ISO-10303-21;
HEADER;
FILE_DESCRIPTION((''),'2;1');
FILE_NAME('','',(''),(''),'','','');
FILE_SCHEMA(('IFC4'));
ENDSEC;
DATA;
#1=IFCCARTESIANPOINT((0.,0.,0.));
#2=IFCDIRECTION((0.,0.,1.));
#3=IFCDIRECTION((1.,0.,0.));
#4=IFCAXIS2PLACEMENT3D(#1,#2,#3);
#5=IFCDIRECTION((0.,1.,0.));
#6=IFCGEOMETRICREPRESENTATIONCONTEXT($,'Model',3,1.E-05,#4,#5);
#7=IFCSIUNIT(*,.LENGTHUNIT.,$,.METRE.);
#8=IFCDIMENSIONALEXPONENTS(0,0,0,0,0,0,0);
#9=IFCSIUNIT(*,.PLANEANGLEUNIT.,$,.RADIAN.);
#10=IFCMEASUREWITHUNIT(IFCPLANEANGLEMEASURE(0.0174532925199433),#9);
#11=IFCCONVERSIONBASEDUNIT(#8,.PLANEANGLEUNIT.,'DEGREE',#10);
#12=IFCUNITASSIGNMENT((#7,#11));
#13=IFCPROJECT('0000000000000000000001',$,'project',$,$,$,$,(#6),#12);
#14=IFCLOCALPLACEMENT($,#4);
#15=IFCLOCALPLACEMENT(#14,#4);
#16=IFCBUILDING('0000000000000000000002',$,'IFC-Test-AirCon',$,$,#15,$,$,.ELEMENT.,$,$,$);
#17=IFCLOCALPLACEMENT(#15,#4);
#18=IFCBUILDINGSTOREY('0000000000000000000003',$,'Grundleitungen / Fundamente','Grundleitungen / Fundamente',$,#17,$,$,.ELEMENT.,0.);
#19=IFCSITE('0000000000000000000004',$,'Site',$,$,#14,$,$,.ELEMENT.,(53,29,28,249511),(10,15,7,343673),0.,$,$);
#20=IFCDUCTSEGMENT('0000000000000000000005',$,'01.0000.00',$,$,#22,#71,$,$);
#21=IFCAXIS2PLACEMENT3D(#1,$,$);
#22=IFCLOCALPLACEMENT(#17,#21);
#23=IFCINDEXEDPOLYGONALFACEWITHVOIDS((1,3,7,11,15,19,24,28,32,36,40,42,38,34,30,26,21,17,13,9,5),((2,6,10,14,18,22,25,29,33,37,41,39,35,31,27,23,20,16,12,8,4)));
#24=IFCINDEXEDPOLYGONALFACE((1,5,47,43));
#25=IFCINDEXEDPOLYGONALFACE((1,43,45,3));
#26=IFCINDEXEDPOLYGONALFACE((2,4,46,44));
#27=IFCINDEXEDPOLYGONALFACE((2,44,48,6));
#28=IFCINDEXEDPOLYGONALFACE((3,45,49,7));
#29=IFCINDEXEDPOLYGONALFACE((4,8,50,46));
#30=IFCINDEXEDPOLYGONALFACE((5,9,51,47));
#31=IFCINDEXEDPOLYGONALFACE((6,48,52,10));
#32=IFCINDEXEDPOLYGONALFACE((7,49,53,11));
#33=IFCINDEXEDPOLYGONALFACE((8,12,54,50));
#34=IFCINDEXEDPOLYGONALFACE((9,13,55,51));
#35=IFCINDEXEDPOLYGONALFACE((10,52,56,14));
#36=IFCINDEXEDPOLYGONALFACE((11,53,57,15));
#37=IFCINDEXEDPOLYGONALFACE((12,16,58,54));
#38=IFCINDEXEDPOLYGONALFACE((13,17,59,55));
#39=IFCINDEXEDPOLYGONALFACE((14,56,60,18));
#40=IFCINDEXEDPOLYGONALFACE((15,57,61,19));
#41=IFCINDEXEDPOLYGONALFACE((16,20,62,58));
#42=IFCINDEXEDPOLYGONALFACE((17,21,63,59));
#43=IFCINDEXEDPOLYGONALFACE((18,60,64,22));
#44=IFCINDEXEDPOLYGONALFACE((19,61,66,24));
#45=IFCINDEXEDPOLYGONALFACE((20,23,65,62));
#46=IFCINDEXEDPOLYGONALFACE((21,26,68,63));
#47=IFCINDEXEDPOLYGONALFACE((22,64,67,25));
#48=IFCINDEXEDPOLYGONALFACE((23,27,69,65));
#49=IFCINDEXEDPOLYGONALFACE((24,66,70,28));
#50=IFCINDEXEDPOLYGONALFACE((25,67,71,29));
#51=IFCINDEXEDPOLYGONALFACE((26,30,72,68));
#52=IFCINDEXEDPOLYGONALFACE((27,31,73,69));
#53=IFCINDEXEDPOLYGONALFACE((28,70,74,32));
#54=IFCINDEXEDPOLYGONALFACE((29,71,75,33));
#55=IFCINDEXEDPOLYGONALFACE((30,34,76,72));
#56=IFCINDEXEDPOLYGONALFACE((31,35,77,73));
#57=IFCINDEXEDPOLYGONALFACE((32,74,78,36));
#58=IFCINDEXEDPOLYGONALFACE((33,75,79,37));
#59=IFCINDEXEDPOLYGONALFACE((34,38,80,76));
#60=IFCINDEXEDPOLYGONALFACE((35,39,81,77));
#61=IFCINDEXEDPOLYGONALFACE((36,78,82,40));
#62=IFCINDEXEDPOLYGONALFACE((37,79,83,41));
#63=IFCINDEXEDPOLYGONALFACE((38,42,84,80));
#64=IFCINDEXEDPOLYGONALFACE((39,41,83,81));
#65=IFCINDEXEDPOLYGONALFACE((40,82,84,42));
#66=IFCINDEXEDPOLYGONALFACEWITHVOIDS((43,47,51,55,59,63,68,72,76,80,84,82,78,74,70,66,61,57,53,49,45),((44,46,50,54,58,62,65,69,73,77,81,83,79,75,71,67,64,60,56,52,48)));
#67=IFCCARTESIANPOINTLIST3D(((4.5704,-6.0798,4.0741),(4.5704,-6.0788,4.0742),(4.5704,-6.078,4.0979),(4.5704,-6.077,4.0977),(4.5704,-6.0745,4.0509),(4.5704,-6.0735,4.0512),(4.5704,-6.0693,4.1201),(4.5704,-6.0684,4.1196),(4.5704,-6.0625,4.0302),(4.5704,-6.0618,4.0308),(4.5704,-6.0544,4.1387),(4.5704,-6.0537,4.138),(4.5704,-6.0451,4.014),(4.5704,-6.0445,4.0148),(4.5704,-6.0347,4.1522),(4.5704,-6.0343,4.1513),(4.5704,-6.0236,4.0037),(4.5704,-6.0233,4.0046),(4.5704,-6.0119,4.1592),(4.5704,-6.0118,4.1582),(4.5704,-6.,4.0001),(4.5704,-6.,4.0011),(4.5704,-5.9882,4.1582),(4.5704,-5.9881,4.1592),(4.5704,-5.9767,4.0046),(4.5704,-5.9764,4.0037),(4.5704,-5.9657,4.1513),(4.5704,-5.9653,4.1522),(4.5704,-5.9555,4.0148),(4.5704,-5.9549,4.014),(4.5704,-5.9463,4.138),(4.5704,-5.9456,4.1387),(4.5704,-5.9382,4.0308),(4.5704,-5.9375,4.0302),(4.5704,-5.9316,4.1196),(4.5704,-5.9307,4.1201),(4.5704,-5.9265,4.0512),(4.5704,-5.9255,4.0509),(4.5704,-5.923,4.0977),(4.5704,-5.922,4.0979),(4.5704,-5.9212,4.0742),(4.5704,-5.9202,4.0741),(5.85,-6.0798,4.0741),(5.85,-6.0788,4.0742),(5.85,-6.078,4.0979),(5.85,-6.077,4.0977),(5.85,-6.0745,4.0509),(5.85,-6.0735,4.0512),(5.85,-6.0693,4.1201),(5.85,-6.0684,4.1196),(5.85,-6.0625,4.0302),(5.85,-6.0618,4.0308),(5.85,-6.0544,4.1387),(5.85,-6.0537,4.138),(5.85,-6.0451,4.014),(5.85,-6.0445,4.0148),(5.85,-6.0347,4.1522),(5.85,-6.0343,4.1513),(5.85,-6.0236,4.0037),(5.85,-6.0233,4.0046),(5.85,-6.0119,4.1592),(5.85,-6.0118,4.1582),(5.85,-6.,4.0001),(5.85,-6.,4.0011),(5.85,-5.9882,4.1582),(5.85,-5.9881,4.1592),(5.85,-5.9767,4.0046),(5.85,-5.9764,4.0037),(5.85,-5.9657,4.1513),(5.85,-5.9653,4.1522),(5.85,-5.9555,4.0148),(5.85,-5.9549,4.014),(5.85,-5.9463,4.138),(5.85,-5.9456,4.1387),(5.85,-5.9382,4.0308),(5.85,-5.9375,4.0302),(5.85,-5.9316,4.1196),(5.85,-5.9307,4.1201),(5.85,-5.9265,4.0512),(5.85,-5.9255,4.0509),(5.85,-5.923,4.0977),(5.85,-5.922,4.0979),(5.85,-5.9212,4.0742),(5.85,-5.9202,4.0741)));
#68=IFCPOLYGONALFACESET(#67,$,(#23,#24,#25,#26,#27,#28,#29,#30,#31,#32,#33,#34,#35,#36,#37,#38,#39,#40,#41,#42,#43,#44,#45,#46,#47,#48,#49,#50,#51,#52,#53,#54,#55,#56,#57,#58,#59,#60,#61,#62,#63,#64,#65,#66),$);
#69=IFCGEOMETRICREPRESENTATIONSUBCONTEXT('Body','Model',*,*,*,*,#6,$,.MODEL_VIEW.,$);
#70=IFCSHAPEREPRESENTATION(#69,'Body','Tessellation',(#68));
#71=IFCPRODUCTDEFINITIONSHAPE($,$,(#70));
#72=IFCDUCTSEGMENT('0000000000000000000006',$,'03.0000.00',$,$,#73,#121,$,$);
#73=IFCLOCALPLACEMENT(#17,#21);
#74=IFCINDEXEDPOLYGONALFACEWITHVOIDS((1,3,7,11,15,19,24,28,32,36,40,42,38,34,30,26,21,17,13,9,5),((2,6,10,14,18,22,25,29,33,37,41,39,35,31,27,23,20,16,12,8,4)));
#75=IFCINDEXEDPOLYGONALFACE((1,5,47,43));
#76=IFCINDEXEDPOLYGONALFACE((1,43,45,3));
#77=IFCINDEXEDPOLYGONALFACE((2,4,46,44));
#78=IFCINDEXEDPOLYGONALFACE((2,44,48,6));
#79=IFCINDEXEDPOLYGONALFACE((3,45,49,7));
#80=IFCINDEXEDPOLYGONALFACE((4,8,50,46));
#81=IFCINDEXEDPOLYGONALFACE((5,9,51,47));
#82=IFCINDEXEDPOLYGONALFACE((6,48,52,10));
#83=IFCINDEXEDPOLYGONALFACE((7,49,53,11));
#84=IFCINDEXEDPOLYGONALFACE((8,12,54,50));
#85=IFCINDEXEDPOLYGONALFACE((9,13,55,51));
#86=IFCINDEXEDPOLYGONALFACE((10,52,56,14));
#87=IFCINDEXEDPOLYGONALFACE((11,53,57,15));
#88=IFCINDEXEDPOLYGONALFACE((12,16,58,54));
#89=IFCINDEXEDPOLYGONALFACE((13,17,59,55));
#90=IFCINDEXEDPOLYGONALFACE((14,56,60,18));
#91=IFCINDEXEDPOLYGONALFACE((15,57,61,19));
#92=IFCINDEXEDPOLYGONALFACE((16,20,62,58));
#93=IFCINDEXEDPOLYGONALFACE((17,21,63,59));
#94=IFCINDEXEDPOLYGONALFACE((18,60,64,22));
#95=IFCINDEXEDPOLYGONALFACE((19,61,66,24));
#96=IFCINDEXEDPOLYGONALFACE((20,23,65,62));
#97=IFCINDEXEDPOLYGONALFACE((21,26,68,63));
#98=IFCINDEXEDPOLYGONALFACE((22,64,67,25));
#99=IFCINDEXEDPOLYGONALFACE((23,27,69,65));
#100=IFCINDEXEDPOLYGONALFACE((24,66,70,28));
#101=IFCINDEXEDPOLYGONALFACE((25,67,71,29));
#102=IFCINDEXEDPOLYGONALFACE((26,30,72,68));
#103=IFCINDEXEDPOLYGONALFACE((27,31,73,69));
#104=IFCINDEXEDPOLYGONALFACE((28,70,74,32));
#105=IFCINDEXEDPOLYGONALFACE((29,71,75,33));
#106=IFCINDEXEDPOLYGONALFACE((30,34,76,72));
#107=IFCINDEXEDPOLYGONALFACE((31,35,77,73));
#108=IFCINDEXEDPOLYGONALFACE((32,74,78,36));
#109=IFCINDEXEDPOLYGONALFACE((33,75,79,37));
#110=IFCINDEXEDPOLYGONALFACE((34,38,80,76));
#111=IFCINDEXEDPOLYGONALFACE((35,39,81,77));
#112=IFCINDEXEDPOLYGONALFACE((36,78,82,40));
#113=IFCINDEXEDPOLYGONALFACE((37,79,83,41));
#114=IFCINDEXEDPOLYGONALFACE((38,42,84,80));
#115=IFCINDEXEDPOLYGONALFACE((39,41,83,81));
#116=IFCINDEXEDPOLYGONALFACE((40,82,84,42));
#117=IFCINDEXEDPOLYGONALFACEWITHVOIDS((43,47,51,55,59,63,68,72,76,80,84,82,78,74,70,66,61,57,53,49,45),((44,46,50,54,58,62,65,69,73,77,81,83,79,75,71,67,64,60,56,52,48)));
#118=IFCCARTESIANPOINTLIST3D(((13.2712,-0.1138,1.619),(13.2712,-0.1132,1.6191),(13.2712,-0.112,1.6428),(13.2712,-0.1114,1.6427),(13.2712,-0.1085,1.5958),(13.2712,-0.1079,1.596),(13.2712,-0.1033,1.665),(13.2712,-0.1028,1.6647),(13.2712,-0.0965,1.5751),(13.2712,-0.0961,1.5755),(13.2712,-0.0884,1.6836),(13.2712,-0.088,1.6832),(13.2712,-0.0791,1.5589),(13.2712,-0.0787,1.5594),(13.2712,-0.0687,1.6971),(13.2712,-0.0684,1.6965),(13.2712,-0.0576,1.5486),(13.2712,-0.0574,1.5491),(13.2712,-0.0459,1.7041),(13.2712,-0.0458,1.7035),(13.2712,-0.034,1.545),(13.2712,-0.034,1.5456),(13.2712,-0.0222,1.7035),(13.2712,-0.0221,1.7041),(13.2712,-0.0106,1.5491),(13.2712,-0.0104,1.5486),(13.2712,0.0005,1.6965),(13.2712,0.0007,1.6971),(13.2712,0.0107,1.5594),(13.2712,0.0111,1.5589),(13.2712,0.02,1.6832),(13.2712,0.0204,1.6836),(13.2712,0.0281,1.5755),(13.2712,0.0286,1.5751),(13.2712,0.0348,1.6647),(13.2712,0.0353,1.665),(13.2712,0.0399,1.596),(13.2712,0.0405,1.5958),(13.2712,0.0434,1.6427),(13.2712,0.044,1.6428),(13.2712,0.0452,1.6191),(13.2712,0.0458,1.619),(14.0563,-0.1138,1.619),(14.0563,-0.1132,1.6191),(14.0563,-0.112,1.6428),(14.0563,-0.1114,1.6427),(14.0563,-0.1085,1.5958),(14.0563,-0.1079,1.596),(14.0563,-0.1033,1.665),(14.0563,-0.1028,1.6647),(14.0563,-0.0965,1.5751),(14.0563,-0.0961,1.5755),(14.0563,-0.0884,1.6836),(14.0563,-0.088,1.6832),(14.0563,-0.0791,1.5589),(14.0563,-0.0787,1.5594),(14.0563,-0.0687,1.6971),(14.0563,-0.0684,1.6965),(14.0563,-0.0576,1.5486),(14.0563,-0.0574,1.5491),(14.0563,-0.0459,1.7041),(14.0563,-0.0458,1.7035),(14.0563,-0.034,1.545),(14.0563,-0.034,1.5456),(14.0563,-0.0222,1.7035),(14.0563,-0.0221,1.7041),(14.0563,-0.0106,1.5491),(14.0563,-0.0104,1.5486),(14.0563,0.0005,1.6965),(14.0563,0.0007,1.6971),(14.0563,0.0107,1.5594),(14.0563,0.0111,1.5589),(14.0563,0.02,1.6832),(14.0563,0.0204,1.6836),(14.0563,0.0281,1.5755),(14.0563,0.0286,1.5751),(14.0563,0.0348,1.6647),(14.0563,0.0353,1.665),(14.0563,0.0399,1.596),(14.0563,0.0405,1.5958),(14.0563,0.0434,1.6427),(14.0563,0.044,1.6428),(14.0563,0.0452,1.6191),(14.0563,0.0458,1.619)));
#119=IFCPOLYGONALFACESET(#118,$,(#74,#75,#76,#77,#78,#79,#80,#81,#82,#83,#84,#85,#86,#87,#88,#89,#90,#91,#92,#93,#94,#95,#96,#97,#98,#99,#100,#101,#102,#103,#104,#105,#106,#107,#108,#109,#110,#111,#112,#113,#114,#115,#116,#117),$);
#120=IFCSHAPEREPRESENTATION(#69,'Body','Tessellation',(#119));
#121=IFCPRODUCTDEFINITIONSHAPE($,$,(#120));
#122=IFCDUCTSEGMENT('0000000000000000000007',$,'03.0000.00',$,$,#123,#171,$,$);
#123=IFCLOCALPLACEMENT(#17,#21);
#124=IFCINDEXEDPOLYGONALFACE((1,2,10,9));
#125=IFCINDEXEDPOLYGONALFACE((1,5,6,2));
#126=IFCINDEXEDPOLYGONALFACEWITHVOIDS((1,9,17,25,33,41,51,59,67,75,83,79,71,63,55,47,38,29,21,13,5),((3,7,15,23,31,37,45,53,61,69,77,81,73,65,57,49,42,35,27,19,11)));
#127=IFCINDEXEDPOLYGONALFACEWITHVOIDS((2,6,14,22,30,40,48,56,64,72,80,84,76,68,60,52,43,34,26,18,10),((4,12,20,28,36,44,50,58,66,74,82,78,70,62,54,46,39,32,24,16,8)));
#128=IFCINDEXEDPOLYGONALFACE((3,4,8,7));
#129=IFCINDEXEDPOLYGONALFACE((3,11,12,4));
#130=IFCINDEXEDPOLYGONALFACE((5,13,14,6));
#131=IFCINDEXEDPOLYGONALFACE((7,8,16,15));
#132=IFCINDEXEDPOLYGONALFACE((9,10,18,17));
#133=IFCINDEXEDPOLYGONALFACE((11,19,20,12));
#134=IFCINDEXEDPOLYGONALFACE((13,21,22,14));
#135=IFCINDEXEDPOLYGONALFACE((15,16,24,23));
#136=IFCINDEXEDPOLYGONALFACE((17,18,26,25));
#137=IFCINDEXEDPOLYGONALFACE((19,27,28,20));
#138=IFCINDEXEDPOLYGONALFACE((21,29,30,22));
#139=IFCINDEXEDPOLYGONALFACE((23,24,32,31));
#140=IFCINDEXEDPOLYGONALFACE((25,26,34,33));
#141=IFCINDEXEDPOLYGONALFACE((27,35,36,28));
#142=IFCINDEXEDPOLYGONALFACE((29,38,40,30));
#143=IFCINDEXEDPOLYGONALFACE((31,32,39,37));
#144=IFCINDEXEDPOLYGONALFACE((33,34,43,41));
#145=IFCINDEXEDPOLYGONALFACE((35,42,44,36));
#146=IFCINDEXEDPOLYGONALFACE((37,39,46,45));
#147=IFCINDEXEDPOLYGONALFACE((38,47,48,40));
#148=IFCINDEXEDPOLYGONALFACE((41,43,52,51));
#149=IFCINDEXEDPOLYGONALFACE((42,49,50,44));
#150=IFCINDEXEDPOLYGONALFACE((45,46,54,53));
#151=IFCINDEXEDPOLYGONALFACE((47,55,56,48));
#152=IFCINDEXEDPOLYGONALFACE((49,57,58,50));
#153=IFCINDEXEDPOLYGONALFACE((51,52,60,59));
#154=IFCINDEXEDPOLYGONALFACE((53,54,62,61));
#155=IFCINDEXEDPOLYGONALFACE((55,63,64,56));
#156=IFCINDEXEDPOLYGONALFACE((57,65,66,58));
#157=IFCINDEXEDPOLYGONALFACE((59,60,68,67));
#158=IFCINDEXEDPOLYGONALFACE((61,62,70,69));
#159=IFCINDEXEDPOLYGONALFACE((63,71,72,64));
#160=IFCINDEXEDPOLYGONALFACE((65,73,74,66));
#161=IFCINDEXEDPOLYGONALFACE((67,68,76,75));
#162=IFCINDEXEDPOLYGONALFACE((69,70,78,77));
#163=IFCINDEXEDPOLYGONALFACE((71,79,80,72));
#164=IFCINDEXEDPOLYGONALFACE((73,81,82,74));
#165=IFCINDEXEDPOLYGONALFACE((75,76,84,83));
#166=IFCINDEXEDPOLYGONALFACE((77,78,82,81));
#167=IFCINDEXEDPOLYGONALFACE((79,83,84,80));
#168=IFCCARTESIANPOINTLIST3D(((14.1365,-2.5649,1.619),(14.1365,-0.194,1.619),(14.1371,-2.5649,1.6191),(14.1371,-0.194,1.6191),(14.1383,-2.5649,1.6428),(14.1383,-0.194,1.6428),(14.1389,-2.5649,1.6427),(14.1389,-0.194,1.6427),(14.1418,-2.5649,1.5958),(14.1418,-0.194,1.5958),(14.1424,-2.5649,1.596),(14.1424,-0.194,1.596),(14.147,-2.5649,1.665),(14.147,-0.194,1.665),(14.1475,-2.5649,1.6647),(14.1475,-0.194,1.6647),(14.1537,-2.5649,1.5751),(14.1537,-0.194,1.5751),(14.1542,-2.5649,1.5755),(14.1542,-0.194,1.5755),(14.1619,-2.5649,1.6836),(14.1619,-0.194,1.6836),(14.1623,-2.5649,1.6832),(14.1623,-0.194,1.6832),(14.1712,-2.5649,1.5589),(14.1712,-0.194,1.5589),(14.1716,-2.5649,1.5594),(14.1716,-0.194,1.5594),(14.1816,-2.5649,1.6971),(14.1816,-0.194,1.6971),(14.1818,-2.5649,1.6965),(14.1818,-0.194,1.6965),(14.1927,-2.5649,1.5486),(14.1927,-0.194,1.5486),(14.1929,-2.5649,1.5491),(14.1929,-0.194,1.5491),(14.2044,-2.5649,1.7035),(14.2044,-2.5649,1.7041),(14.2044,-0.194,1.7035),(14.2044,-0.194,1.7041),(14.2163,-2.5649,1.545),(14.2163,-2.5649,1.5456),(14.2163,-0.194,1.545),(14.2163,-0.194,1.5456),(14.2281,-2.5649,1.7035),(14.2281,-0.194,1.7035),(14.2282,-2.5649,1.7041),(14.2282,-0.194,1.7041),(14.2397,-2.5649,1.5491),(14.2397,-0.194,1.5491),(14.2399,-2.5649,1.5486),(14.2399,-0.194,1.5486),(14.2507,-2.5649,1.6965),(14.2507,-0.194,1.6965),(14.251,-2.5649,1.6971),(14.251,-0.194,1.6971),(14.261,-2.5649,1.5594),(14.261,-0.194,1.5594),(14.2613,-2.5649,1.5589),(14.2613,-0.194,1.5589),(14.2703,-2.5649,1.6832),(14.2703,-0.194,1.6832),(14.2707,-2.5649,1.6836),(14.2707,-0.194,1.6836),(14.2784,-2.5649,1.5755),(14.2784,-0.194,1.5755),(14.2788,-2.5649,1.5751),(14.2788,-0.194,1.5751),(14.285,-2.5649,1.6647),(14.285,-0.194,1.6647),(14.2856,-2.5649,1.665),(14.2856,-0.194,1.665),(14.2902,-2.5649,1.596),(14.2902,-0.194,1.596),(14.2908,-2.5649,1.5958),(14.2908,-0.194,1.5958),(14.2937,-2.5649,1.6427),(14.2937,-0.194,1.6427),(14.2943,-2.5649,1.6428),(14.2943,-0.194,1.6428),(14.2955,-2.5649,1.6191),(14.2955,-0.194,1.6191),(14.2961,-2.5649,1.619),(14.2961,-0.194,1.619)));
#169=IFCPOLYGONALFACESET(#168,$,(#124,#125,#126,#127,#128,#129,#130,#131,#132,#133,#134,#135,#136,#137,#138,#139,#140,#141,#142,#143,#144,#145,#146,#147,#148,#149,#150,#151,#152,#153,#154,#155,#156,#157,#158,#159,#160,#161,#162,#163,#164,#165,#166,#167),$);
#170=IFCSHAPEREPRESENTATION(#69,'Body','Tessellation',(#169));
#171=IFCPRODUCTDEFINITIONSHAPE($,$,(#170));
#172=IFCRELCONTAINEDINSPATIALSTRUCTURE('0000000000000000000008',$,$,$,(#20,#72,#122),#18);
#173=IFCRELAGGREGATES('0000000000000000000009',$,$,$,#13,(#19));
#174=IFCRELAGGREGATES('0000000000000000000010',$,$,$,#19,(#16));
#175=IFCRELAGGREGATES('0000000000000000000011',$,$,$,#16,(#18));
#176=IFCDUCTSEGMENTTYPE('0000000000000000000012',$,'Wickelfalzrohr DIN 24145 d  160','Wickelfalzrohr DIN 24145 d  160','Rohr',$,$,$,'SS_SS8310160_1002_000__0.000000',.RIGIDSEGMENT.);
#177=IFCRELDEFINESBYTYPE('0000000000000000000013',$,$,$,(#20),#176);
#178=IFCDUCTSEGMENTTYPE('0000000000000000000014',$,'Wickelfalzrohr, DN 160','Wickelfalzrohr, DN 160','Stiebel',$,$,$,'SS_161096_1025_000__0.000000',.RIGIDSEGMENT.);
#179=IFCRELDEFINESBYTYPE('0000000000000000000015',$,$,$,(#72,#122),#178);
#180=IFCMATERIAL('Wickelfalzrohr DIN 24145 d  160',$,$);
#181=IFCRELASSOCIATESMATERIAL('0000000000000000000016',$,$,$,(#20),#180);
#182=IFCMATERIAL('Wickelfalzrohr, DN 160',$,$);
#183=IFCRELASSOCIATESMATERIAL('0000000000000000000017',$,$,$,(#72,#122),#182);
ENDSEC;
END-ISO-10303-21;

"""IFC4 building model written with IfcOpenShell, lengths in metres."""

from ifc_helpers import new_model, entity, si_unit, converted_unit, direction, frame, origin_with_axes, origin_2d_with_axis, place, context, subcontext, project, spatial, hollow_circle, extrude, material, type_object, element, save


model = new_model("IFC4")

# Units and contexts
model_context = context("Model", 3, precision=1e-05, world=origin_with_axes(), true_north=direction((0.0, 1.0, 0.0)))
body_context = subcontext(model_context, "Body", "Model", "MODEL_VIEW")
ifc_project = project(units=[si_unit("LENGTHUNIT", "METRE"), converted_unit("PLANEANGLEUNIT", "DEGREE", entity("IfcPlaneAngleMeasure", 0.0174532925199433), si_unit("PLANEANGLEUNIT", "RADIAN"), dimensions=[0, 0, 0, 0, 0, 0, 0])], contexts=[model_context])

# Site, building, storey
site_placement = place(None, origin_with_axes())
site = spatial("IfcSite", under=ifc_project, at=site_placement, Name="Site", CompositionType="ELEMENT", RefLatitude=(53, 29, 28, 249511), RefLongitude=(10, 15, 7, 343673), RefElevation=0.0)
building_placement = place(site_placement, origin_with_axes())
building = spatial("IfcBuilding", under=site, at=building_placement, Name="IFC-Test-AirCon", CompositionType="ELEMENT")
storey_placement = place(building_placement, origin_with_axes())
storey = spatial("IfcBuildingStorey", under=building, at=storey_placement, Name="Grundleitungen / Fundamente", Description="Grundleitungen / Fundamente", CompositionType="ELEMENT", Elevation=0.0)

# Duct segments
ifc_material_1 = material(Name="Wickelfalzrohr DIN 24145 d  160")
duct_segment_type_1 = type_object("IfcDuctSegmentType", Name="Wickelfalzrohr DIN 24145 d  160", Description="Wickelfalzrohr DIN 24145 d  160", ApplicableOccurrence="Rohr", ElementType="SS_SS8310160_1002_000__0.000000", PredefinedType="RIGIDSEGMENT")
duct_segment_1_placement = place(storey_placement, frame((5.85, -6.0, 4.0801), z_axis=(0.0, 0.0, 1.0), x_axis=(-1.0, 0.0, 0.0)))
element("IfcDuctSegment", 1, at=duct_segment_1_placement, inside=storey, type_object=duct_segment_type_1, material=ifc_material_1, Name="01.0000.00", context=body_context, shape_type="SweptSolid", body=[
    extrude(hollow_circle(Radius=0.08, WallThickness=0.001, at=origin_2d_with_axis()), frame((0.0, 0.0, 0.0), z_axis=(1.0, 0.0, 0.0), x_axis=(0.0, 0.0, -1.0)), (0.0, 0.0, 1.0), 1.2796),
])
ifc_material_2 = material(Name="Wickelfalzrohr, DN 160")
duct_segment_type_2 = type_object("IfcDuctSegmentType", Name="Wickelfalzrohr, DN 160", Description="Wickelfalzrohr, DN 160", ApplicableOccurrence="Stiebel", ElementType="SS_161096_1025_000__0.000000", PredefinedType="RIGIDSEGMENT")
duct_segment_2_placement = place(storey_placement, frame((13.2712, -0.034, 1.625), z_axis=(0.0, 0.0, 1.0), x_axis=(1.0, 0.0, 0.0)))
element("IfcDuctSegment", 2, at=duct_segment_2_placement, inside=storey, type_object=duct_segment_type_2, material=ifc_material_2, Name="03.0000.00", context=body_context, shape_type="SweptSolid", body=[
    extrude(hollow_circle(Radius=0.08, WallThickness=0.0006, at=origin_2d_with_axis()), frame((0.0, 0.0, 0.0), z_axis=(1.0, 0.0, 0.0), x_axis=(0.0, 0.0, -1.0)), (0.0, 0.0, 1.0), 0.7851),
])
duct_segment_3_placement = place(storey_placement, frame((14.2163, -0.194, 1.625), z_axis=(0.0, 0.0, 1.0), x_axis=(0.0, -1.0, 0.0)))
element("IfcDuctSegment", 3, at=duct_segment_3_placement, inside=storey, type_object=duct_segment_type_2, material=ifc_material_2, Name="03.0000.00", context=body_context, shape_type="SweptSolid", body=[
    extrude(hollow_circle(Radius=0.08, WallThickness=0.0006, at=origin_2d_with_axis()), frame((0.0, 0.0, 0.0), z_axis=(1.0, 0.0, 0.0), x_axis=(0.0, 0.0, -1.0)), (0.0, 0.0, 1.0), 2.3709),
])

save(model, "model.ifc")
